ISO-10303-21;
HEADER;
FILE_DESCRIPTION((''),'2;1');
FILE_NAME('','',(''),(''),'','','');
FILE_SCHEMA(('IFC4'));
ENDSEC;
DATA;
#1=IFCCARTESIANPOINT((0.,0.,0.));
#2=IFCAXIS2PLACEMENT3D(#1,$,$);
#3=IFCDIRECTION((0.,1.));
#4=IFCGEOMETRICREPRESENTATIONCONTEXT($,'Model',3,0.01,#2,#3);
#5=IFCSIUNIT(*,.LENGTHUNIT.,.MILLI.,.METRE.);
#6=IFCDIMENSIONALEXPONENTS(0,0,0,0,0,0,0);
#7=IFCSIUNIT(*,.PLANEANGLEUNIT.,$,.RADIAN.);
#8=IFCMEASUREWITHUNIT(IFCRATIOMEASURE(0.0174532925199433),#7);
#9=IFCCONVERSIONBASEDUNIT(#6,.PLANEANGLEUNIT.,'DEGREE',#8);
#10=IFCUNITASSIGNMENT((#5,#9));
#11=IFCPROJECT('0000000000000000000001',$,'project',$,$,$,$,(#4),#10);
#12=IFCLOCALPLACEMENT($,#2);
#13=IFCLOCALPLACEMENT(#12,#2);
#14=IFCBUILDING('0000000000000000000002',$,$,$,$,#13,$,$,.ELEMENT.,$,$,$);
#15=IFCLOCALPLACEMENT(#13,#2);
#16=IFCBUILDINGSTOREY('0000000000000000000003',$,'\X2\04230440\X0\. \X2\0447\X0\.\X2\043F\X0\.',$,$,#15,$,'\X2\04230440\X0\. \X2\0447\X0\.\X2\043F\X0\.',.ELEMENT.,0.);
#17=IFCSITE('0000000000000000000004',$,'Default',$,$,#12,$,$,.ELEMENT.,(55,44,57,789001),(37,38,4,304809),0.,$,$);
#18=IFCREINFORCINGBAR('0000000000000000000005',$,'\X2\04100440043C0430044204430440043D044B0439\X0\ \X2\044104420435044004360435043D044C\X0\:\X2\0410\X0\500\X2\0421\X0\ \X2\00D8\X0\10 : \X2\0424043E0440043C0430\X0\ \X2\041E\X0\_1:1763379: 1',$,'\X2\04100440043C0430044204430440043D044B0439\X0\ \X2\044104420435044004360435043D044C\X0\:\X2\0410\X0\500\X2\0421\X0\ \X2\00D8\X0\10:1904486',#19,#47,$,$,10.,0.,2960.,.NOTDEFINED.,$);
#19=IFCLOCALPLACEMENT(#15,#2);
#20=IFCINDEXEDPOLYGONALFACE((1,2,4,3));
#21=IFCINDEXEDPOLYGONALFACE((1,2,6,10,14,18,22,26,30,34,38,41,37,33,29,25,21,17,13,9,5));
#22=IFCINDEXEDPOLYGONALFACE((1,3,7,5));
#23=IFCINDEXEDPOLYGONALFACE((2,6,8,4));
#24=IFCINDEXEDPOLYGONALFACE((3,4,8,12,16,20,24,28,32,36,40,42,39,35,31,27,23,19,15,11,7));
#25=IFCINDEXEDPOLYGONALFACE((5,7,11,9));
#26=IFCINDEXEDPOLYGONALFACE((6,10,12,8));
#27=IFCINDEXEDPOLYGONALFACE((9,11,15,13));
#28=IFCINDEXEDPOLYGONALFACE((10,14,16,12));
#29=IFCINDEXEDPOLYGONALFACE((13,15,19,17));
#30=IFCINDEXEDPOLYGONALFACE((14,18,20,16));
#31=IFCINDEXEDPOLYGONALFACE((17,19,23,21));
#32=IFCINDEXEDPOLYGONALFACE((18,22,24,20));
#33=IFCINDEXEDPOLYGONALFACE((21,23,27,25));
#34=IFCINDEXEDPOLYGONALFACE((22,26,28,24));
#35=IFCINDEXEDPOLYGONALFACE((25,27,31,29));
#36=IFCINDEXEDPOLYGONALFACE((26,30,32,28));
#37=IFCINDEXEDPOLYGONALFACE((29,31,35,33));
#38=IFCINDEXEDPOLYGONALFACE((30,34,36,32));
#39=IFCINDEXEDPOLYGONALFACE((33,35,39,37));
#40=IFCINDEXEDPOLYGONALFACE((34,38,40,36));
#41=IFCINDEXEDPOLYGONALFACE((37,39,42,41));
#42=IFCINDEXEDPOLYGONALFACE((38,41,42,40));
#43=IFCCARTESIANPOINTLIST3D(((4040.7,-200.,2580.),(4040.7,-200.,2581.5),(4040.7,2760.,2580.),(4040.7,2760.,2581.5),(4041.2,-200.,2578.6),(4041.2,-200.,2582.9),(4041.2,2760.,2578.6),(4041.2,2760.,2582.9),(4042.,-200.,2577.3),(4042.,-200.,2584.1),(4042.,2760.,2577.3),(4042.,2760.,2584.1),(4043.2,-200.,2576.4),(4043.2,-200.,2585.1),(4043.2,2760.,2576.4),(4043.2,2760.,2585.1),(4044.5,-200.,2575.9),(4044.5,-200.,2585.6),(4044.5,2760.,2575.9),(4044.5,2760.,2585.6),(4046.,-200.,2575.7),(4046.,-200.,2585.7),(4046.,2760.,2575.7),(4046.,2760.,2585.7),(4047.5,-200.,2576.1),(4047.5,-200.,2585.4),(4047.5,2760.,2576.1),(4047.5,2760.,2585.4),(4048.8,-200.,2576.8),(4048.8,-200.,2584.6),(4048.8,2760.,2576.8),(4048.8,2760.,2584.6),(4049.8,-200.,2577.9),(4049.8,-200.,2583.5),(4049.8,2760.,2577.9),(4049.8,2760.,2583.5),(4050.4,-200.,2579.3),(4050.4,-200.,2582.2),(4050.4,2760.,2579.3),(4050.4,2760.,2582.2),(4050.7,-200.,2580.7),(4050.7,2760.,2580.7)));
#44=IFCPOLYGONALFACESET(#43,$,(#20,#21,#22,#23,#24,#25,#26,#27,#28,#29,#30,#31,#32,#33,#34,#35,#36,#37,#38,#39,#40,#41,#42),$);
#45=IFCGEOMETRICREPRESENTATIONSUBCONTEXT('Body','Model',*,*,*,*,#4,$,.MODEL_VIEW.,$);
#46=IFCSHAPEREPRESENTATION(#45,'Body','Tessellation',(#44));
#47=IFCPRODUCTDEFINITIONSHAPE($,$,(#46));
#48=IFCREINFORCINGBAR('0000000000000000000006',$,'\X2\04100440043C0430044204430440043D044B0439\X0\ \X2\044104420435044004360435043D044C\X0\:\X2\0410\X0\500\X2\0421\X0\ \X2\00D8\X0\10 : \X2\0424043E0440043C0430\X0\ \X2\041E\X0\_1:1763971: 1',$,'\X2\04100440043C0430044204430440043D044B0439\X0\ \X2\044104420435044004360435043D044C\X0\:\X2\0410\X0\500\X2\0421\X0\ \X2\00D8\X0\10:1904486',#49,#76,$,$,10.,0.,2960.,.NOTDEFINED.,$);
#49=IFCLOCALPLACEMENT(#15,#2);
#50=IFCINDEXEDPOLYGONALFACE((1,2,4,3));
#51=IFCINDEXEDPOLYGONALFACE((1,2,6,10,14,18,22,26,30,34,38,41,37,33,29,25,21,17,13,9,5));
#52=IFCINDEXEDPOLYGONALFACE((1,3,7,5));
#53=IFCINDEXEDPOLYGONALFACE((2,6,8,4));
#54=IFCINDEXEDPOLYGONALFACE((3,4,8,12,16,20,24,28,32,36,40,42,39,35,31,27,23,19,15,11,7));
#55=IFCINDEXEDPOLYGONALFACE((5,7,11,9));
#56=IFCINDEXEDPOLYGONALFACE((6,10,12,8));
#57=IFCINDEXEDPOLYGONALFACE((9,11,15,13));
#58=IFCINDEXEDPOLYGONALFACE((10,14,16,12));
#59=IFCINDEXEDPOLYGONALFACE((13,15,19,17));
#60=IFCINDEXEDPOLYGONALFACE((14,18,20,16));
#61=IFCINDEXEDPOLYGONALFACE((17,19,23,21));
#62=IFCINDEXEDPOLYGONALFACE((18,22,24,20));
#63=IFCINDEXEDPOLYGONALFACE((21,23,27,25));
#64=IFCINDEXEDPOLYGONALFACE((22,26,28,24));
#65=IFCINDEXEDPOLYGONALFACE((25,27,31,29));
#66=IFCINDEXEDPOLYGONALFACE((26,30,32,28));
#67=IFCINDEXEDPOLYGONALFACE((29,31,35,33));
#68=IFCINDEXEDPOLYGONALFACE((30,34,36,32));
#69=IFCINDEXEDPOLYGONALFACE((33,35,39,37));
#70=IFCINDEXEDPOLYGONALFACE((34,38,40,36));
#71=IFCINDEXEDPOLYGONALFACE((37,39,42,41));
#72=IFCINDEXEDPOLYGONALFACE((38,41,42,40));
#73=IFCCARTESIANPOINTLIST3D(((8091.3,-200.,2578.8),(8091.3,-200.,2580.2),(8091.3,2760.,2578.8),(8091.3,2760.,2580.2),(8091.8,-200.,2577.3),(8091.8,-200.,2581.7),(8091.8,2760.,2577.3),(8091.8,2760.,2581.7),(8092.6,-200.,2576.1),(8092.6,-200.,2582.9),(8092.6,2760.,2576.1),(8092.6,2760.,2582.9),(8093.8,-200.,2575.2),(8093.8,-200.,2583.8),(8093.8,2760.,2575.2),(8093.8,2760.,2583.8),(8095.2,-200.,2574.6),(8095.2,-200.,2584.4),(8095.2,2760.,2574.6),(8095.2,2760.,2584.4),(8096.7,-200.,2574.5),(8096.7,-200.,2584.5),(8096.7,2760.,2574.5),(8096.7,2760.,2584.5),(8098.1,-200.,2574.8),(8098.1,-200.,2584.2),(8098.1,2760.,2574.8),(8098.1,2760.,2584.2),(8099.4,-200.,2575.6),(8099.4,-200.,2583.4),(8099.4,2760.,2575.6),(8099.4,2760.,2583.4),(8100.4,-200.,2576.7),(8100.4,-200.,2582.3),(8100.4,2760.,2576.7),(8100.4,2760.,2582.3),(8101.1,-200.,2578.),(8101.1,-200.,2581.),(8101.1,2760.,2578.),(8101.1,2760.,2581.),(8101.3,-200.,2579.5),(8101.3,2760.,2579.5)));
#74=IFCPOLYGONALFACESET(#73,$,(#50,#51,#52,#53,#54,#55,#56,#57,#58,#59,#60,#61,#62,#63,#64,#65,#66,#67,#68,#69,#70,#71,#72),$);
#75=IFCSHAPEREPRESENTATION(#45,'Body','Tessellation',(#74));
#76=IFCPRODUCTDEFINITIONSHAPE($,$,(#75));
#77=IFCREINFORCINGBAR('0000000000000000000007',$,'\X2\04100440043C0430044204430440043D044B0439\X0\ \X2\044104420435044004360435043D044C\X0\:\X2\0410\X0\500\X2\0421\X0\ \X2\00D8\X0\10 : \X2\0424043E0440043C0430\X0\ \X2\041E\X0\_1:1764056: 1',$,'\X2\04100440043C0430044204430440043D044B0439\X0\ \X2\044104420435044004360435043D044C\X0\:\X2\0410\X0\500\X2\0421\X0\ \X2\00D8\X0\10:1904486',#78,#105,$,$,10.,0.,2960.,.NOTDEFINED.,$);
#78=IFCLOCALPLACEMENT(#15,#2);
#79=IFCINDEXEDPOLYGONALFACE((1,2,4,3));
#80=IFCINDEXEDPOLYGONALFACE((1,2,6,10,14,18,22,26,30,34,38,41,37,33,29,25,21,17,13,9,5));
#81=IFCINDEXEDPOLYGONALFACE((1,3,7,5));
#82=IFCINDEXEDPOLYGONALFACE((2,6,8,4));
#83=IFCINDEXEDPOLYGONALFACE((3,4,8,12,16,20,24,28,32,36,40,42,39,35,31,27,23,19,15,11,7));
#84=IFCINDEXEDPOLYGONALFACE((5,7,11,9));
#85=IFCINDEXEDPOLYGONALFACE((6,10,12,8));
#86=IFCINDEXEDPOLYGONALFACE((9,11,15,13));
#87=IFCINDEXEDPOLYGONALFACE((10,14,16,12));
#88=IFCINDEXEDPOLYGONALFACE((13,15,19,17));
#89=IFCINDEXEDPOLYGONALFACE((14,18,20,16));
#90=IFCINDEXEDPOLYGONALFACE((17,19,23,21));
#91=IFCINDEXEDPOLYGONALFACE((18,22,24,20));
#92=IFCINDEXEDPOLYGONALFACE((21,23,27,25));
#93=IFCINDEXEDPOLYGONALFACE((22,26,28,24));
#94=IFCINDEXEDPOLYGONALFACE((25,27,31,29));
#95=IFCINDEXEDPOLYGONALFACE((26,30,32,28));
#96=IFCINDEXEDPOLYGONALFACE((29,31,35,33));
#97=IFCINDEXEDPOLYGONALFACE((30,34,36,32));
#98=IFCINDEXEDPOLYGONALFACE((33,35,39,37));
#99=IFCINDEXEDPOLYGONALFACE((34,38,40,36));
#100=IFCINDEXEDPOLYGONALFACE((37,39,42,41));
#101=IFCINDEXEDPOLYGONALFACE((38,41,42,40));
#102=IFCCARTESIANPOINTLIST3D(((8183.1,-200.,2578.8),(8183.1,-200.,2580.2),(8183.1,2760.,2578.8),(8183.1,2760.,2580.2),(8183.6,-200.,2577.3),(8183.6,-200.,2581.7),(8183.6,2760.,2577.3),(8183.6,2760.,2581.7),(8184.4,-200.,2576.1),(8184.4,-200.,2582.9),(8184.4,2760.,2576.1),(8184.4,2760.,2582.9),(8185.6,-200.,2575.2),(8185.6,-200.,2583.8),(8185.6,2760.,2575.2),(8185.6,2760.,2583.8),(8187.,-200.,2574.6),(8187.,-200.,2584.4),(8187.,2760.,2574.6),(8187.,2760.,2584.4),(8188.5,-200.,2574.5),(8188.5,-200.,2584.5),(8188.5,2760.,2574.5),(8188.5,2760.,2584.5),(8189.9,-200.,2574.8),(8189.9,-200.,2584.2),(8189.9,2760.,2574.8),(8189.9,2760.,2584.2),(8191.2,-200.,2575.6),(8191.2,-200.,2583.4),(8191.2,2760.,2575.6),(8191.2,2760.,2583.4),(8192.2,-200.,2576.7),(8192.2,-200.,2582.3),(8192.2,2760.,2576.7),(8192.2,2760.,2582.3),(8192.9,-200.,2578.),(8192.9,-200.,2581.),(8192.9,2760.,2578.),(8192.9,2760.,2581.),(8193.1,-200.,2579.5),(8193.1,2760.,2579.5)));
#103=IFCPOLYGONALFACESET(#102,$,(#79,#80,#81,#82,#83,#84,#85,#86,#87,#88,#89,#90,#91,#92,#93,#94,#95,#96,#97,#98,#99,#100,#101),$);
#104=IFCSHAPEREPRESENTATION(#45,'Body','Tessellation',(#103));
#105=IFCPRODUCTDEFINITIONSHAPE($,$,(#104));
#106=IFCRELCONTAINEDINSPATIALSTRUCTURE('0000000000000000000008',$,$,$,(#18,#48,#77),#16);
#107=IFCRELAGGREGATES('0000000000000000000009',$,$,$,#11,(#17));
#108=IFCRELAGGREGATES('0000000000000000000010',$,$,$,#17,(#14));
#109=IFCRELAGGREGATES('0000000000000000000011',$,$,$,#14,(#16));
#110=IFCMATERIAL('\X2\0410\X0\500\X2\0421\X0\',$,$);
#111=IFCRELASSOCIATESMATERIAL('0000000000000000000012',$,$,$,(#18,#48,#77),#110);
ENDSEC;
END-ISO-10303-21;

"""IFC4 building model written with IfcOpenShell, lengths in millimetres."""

from ifc_helpers import new_model, entity, si_unit, converted_unit, direction, origin, place, context, subcontext, project, spatial, material, element, save


model = new_model("IFC4")

# Units and contexts
model_context = context("Model", 3, precision=0.01, world=origin(), true_north=direction((0.0, 1.0)))
body_context = subcontext(model_context, "Body", "Model", "MODEL_VIEW")
ifc_project = project(units=[si_unit("LENGTHUNIT", "METRE", prefix="MILLI"), converted_unit("PLANEANGLEUNIT", "DEGREE", entity("IfcRatioMeasure", 0.0174532925199433), si_unit("PLANEANGLEUNIT", "RADIAN"), dimensions=[0, 0, 0, 0, 0, 0, 0])], contexts=[model_context])

# Site, building, storey
site_placement = place(None, origin())
site = spatial("IfcSite", under=ifc_project, at=site_placement, Name="Default", CompositionType="ELEMENT", RefLatitude=(55, 44, 57, 789001), RefLongitude=(37, 38, 4, 304809), RefElevation=0.0)
building_placement = place(site_placement, origin())
building = spatial("IfcBuilding", under=site, at=building_placement, CompositionType="ELEMENT")
storey_placement = place(building_placement, origin())
storey = spatial("IfcBuildingStorey", under=building, at=storey_placement, Name="Ур. ч.п.", LongName="Ур. ч.п.", CompositionType="ELEMENT", Elevation=0.0)

# Reinforcing bars
ifc_material_1 = material(Name="А500С")
reinforcing_bar_1_placement = place(storey_placement, origin())
element("IfcReinforcingBar", 1, at=reinforcing_bar_1_placement, inside=storey, material=ifc_material_1, Name="Арматурный стержень:А500С Ø10 : Форма О_1:1763379: 1", ObjectType="Арматурный стержень:А500С Ø10:1904486", BarLength=2960.0, CrossSectionArea=0.0, NominalDiameter=10.0, PredefinedType="NOTDEFINED", context=body_context, shape_type="AdvancedSweptSolid", body=[
    entity("IfcSweptDiskSolid", entity("IfcCompositeCurve", [entity("IfcCompositeCurveSegment", "CONTINUOUS", True, entity("IfcPolyline", [entity("IfcCartesianPoint", [4045.7, -200.0, 2580.7]), entity("IfcCartesianPoint", [4045.7, 2760.0, 2580.7])]))], False), 5.0, None, 0.0, 1.0),
])
reinforcing_bar_2_placement = place(storey_placement, origin())
element("IfcReinforcingBar", 2, at=reinforcing_bar_2_placement, inside=storey, material=ifc_material_1, Name="Арматурный стержень:А500С Ø10 : Форма О_1:1763971: 1", ObjectType="Арматурный стержень:А500С Ø10:1904486", BarLength=2960.0, CrossSectionArea=0.0, NominalDiameter=10.0, PredefinedType="NOTDEFINED", context=body_context, shape_type="AdvancedSweptSolid", body=[
    entity("IfcSweptDiskSolid", entity("IfcCompositeCurve", [entity("IfcCompositeCurveSegment", "CONTINUOUS", True, entity("IfcPolyline", [entity("IfcCartesianPoint", [8096.3, -200.0, 2579.5]), entity("IfcCartesianPoint", [8096.3, 2760.0, 2579.5])]))], False), 5.0, None, 0.0, 1.0),
])
reinforcing_bar_3_placement = place(storey_placement, origin())
element("IfcReinforcingBar", 3, at=reinforcing_bar_3_placement, inside=storey, material=ifc_material_1, Name="Арматурный стержень:А500С Ø10 : Форма О_1:1764056: 1", ObjectType="Арматурный стержень:А500С Ø10:1904486", BarLength=2960.0, CrossSectionArea=0.0, NominalDiameter=10.0, PredefinedType="NOTDEFINED", context=body_context, shape_type="AdvancedSweptSolid", body=[
    entity("IfcSweptDiskSolid", entity("IfcCompositeCurve", [entity("IfcCompositeCurveSegment", "CONTINUOUS", True, entity("IfcPolyline", [entity("IfcCartesianPoint", [8188.1, -200.0, 2579.5]), entity("IfcCartesianPoint", [8188.1, 2760.0, 2579.5])]))], False), 5.0, None, 0.0, 1.0),
])

save(model, "model.ifc")
